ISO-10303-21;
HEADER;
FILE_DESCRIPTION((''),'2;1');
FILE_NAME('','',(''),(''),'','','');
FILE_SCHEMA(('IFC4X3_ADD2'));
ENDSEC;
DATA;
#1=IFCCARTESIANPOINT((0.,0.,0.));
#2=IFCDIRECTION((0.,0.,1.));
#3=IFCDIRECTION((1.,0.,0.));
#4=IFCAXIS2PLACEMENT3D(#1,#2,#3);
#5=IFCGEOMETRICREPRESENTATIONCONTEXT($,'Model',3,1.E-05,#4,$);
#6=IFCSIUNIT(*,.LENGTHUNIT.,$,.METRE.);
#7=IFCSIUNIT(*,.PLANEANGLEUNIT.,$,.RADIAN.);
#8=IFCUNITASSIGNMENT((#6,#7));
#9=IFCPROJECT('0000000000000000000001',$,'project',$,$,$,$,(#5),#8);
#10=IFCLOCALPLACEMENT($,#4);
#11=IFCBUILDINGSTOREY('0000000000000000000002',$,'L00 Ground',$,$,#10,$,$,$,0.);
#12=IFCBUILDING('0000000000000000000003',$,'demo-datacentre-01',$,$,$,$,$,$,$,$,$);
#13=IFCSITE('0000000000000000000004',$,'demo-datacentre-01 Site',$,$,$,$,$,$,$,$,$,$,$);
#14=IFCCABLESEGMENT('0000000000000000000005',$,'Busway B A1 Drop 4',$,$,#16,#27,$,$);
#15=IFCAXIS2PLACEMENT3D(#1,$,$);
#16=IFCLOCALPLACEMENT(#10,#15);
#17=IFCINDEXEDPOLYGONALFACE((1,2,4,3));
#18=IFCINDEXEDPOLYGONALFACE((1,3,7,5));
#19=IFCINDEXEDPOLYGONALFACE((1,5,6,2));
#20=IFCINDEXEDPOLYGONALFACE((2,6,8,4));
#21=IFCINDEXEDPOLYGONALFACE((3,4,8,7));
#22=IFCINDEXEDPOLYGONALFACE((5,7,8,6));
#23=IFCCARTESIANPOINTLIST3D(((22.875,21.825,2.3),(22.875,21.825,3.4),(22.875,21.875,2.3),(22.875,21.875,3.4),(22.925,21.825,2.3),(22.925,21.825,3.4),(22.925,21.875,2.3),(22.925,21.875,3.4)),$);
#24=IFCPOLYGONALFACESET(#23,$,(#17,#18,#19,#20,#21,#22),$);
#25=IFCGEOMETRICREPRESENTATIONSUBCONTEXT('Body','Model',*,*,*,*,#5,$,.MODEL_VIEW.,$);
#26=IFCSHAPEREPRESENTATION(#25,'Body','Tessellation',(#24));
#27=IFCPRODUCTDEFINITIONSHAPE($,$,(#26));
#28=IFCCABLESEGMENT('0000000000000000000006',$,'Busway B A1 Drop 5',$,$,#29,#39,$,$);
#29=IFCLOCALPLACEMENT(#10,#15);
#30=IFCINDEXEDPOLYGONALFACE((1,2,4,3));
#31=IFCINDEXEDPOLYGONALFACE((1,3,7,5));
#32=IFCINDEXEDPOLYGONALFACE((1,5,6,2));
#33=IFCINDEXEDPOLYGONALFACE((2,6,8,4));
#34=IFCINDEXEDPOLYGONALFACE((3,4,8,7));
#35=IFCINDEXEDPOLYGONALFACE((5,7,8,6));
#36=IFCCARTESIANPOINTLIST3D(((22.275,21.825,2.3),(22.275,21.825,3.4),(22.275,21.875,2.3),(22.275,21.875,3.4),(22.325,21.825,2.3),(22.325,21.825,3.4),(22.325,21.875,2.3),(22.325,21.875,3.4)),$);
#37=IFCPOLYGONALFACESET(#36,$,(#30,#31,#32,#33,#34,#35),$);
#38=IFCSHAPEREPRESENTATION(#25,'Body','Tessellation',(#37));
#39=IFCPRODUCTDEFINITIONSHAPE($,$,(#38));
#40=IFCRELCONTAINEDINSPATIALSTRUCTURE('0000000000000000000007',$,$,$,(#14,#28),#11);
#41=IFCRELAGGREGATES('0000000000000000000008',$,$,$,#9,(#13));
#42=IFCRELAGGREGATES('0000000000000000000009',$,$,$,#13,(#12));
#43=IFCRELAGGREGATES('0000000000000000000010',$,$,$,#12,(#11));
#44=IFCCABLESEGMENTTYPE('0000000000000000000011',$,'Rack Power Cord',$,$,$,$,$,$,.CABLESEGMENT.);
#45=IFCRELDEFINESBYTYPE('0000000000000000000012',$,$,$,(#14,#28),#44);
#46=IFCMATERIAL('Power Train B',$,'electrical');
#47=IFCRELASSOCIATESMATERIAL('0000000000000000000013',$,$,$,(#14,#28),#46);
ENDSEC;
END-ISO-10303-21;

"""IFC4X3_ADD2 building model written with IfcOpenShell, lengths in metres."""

from ifc_helpers import new_model, si_unit, frame, origin_with_axes, place, context, subcontext, project, spatial, rectangle, extrude, material, type_object, element, save


model = new_model("IFC4X3_ADD2")

# Units and contexts
model_context = context("Model", 3, precision=1e-05, world=origin_with_axes())
body_context = subcontext(model_context, "Body", "Model", "MODEL_VIEW")
ifc_project = project(units=[si_unit("LENGTHUNIT", "METRE"), si_unit("PLANEANGLEUNIT", "RADIAN")], contexts=[model_context])

# Site, building, storey
site = spatial("IfcSite", under=ifc_project, Name="demo-datacentre-01 Site")
building = spatial("IfcBuilding", under=site, Name="demo-datacentre-01")
storey_placement = place(None, origin_with_axes())
storey = spatial("IfcBuildingStorey", under=building, at=storey_placement, Name="L00 Ground", Elevation=0.0)

# Shared definitions
ifc_material_1 = material(Name="Power Train B", Category="electrical")

# Cable segments
cable_segment_type_1 = type_object("IfcCableSegmentType", Name="Rack Power Cord", PredefinedType="CABLESEGMENT")
for number, where, z_axis, x_axis, name in (
    (1, (22.9, 21.85, 3.4), (0.0, 0.0, -1.0), (1.0, 0.0, 0.0), "Busway B A1 Drop 4"),
    (2, (22.3, 21.85, 3.4), (0.0, 0.0, -1.0), (1.0, 0.0, 0.0), "Busway B A1 Drop 5"),
):
    element("IfcCableSegment", number, at=place(storey_placement, frame(where, z_axis=z_axis, x_axis=x_axis)), inside=storey, type_object=cable_segment_type_1, material=ifc_material_1, Name=name, context=body_context, shape_type="SweptSolid", body=[
        extrude(rectangle(XDim=0.05, YDim=0.05), origin_with_axes(), (0.0, 0.0, 1.0), 1.1),
    ])

save(model, "model.ifc")
